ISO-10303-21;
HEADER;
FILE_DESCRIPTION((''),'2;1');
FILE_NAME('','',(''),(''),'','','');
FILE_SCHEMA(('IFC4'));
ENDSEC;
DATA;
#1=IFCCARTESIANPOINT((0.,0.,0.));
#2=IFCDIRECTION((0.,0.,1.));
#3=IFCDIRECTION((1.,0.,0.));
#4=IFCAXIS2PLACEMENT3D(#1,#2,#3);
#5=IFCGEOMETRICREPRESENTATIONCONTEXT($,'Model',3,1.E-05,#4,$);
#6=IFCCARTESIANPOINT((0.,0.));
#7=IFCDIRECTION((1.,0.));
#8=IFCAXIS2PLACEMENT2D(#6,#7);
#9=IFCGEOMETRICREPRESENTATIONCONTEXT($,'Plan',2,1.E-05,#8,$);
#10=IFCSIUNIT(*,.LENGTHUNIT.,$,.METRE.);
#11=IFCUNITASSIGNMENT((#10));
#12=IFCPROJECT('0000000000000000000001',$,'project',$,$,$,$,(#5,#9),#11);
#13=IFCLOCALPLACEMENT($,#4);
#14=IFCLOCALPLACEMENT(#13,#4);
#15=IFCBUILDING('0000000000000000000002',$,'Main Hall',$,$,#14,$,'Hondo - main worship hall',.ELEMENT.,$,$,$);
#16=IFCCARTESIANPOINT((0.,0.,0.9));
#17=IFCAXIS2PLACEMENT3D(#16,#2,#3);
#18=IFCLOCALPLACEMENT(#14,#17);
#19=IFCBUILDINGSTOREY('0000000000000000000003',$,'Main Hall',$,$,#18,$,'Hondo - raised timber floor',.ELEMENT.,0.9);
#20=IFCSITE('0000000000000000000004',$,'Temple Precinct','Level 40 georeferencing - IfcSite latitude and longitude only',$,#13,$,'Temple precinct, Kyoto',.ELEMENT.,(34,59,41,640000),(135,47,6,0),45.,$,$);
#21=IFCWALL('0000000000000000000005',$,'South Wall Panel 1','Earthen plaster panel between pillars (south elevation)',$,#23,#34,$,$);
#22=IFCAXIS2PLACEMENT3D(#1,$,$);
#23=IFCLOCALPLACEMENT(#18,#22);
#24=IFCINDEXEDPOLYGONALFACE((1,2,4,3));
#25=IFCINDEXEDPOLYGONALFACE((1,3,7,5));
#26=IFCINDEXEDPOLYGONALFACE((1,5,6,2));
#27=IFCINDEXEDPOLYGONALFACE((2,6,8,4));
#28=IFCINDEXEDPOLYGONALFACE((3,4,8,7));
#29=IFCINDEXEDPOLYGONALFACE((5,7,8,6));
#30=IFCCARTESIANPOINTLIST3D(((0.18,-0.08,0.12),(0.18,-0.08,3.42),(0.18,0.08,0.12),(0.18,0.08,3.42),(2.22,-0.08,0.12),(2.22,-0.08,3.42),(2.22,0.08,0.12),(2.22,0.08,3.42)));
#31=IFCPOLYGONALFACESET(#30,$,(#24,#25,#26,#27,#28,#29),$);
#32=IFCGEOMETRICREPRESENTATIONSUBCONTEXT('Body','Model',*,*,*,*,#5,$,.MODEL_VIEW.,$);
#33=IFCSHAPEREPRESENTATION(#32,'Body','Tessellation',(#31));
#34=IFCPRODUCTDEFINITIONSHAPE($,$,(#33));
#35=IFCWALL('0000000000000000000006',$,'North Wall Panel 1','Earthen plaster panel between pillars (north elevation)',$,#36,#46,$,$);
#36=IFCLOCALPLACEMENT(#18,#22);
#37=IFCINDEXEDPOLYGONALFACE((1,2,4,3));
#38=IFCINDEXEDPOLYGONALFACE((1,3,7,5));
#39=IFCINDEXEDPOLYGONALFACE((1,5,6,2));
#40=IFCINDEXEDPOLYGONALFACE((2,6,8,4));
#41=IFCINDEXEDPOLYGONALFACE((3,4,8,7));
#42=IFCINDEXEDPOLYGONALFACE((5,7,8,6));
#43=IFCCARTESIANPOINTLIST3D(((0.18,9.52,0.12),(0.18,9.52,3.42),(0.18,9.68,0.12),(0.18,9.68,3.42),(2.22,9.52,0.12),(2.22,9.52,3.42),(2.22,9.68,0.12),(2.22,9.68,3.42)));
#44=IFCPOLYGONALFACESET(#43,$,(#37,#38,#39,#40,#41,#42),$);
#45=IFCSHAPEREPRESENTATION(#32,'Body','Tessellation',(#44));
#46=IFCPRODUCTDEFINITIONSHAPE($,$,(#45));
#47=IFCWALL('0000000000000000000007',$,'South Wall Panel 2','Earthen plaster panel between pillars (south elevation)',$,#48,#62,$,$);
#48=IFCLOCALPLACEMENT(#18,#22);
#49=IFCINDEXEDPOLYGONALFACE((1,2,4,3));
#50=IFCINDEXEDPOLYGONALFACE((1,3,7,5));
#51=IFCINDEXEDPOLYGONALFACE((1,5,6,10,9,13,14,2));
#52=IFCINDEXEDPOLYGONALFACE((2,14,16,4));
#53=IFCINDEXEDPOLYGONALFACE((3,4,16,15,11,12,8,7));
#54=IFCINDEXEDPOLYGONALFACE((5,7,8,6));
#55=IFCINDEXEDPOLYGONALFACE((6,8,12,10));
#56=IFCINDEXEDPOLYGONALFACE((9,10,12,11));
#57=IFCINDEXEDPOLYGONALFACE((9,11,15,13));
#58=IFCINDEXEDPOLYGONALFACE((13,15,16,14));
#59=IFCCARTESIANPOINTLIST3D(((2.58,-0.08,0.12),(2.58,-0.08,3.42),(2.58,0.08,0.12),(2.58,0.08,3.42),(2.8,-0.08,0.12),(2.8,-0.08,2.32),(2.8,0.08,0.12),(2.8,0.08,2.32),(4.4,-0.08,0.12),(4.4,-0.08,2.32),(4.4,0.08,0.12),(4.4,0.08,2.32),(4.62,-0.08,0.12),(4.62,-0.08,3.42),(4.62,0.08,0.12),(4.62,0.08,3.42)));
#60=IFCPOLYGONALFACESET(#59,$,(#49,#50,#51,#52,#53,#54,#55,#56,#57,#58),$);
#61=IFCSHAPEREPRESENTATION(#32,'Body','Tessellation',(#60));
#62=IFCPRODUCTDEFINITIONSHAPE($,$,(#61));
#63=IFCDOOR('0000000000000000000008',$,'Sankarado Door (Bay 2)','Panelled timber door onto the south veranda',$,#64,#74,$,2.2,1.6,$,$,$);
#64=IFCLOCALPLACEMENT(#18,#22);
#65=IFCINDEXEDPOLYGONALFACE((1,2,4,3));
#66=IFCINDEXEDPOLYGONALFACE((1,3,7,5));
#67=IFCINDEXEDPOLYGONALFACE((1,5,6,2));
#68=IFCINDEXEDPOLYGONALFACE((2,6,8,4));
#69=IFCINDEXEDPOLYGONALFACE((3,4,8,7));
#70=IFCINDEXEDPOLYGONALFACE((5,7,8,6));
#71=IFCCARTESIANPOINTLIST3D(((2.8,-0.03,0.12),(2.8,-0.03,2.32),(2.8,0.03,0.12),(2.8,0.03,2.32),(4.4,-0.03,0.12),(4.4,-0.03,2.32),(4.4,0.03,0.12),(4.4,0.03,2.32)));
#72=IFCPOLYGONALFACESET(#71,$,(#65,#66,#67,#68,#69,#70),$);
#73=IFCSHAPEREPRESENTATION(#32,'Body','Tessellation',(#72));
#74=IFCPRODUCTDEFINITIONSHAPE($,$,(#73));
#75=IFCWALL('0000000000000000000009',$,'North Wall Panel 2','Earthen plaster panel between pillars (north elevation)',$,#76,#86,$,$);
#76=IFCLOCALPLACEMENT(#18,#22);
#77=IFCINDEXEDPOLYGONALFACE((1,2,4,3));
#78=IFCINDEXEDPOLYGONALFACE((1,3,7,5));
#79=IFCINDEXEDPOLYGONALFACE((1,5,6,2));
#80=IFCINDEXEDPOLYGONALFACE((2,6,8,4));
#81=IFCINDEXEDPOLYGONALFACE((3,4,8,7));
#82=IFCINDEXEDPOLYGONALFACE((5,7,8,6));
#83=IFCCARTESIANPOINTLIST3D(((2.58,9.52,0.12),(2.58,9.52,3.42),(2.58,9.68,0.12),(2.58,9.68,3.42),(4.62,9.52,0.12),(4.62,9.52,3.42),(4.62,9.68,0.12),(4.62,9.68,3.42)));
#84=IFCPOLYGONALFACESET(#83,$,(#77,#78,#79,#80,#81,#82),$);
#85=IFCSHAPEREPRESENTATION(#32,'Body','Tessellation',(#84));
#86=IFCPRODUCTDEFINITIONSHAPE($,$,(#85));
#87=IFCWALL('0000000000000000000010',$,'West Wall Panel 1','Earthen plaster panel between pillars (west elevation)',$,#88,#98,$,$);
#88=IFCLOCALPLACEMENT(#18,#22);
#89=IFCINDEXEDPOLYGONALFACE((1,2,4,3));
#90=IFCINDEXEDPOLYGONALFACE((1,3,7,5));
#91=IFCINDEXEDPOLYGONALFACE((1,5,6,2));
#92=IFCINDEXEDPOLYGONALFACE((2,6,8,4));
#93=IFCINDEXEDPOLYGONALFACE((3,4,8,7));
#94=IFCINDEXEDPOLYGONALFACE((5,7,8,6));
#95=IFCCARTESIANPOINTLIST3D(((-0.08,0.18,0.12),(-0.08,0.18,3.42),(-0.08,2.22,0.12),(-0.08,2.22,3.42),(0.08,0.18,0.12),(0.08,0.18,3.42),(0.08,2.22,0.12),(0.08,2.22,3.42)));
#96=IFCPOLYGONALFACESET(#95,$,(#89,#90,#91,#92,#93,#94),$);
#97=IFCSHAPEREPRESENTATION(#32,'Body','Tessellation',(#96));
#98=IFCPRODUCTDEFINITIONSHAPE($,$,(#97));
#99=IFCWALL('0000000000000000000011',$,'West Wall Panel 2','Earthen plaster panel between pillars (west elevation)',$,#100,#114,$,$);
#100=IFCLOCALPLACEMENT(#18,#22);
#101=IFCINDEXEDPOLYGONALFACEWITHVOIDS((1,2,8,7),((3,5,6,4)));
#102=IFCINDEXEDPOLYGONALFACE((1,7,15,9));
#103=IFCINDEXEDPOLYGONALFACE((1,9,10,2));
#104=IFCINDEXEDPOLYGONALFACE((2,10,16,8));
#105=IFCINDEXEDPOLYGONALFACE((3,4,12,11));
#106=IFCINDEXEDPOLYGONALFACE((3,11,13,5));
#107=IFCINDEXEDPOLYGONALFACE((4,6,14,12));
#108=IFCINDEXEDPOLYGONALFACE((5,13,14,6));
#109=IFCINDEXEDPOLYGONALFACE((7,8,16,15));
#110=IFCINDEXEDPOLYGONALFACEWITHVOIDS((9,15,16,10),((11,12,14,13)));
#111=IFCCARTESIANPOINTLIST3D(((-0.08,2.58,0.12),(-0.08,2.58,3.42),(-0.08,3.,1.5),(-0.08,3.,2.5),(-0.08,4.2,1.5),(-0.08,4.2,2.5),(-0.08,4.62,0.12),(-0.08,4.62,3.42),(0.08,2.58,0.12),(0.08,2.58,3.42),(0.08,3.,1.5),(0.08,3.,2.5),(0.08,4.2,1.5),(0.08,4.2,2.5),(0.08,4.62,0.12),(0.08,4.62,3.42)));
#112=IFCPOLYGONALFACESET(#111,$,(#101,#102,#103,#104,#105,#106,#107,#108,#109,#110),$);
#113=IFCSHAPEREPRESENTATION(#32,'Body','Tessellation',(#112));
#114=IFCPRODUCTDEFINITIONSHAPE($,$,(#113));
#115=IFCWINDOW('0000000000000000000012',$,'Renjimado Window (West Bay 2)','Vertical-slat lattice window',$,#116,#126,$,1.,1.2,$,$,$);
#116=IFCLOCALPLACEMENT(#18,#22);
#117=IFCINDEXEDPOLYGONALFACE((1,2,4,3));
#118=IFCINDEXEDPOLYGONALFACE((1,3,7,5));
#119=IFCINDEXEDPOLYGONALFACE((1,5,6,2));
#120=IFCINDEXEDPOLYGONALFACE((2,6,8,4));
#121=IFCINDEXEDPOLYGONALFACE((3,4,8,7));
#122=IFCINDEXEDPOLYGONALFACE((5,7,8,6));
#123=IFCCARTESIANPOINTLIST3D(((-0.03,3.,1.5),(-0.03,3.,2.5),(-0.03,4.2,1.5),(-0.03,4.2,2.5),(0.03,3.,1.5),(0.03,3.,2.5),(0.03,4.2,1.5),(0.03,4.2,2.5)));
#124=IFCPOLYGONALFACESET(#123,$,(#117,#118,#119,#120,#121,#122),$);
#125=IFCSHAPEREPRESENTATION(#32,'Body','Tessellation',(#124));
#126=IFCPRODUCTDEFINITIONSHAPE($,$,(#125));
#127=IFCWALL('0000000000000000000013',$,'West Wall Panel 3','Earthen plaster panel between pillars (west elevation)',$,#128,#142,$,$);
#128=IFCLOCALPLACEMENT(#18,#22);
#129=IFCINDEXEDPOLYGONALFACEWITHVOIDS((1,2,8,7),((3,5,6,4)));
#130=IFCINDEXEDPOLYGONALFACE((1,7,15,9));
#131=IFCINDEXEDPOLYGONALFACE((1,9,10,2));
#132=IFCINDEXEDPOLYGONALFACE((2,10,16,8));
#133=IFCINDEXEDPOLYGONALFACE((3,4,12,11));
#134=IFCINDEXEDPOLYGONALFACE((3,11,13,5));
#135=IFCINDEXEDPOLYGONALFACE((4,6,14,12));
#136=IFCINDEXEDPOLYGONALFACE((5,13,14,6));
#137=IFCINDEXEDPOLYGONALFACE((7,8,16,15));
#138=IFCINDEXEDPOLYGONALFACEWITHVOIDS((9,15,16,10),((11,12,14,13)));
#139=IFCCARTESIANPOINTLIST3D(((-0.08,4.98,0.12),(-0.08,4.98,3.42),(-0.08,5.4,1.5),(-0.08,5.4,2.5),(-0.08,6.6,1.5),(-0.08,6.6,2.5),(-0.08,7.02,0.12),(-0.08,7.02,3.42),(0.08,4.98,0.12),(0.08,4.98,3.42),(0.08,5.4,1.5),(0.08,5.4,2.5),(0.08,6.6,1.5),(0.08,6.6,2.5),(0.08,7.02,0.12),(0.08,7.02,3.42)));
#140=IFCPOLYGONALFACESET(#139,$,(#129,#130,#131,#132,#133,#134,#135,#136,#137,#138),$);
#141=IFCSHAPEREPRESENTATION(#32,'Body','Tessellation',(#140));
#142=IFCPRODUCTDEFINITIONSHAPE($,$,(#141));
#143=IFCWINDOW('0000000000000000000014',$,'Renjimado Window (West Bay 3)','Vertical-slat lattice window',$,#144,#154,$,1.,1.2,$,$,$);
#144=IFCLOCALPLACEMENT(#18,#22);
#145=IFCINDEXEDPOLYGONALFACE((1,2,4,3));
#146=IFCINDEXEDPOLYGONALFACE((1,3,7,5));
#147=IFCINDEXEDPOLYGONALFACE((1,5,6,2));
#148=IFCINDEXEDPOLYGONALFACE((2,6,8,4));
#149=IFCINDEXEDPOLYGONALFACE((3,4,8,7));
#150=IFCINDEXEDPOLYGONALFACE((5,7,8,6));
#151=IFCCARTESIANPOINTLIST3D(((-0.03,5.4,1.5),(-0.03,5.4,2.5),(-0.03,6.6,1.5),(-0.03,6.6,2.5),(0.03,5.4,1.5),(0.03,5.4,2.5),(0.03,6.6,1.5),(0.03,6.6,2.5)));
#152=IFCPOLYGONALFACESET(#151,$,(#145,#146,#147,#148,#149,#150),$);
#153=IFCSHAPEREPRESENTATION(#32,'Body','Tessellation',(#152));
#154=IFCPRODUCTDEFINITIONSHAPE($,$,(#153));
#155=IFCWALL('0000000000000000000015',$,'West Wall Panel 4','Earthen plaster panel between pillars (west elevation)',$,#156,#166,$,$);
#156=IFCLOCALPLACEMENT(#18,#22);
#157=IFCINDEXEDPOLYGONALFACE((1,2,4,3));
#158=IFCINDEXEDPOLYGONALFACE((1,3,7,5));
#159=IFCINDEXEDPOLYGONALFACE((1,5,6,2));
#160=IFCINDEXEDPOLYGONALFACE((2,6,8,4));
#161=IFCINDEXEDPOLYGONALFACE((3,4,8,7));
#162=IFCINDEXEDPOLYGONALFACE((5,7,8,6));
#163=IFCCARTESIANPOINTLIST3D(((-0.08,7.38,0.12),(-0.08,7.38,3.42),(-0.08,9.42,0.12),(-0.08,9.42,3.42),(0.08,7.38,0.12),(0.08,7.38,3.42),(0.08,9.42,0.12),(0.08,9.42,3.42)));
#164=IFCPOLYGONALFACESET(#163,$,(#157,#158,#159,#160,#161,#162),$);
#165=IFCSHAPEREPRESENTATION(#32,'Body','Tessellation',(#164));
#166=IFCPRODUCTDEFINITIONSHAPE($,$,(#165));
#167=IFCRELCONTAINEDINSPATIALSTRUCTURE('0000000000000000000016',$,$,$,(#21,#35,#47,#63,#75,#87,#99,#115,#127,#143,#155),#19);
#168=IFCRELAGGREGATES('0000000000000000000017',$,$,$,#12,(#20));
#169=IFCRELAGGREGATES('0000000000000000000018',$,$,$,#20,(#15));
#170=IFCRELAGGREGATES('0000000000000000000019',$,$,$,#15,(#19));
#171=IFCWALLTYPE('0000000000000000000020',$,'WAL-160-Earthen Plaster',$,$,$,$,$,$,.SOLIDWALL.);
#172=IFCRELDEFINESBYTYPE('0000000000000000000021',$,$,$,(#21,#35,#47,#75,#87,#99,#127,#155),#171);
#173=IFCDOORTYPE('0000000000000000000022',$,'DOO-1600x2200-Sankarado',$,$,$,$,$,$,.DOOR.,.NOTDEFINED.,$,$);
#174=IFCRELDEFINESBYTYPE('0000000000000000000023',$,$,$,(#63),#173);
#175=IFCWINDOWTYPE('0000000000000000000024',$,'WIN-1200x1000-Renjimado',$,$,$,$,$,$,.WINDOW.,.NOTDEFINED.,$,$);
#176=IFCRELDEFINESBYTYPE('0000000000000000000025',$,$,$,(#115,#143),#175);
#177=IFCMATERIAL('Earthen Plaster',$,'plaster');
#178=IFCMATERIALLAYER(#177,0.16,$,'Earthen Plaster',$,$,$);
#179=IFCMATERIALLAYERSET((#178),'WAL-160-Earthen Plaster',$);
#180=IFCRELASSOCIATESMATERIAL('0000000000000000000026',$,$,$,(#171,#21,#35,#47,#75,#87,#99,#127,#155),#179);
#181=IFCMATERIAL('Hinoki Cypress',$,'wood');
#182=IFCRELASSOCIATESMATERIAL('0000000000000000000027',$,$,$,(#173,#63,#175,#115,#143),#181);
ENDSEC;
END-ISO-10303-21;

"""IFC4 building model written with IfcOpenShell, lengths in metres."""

from ifc_helpers import new_model, si_unit, frame, origin_with_axes, origin_2d_with_axis, place, context, subcontext, project, spatial, line, indexed_curve, outline, extrude, material, layer, layer_set, layer_usage, type_object, element, fill, save


model = new_model("IFC4")

# Units and contexts
model_context = context("Model", 3, precision=1e-05, world=origin_with_axes())
plan_context = context("Plan", 2, precision=1e-05, world=origin_2d_with_axis())
body_context = subcontext(model_context, "Body", "Model", "MODEL_VIEW")
ifc_project = project(units=[si_unit("LENGTHUNIT", "METRE")], contexts=[model_context, plan_context])

# Site, building, storey
site_placement = place(None, origin_with_axes())
site = spatial("IfcSite", under=ifc_project, at=site_placement, Name="Temple Precinct", Description="Level 40 georeferencing - IfcSite latitude and longitude only", LongName="Temple precinct, Kyoto", CompositionType="ELEMENT", RefLatitude=(34, 59, 41, 640000), RefLongitude=(135, 47, 6, 0), RefElevation=45.0)
building_placement = place(site_placement, origin_with_axes())
building = spatial("IfcBuilding", under=site, at=building_placement, Name="Main Hall", LongName="Hondo - main worship hall", CompositionType="ELEMENT")
storey_placement = place(building_placement, frame((0.0, 0.0, 0.9), z_axis=(0.0, 0.0, 1.0), x_axis=(1.0, 0.0, 0.0)))
storey = spatial("IfcBuildingStorey", under=building, at=storey_placement, Name="Main Hall", LongName="Hondo - raised timber floor", CompositionType="ELEMENT", Elevation=0.9)

# Shared definitions
ifc_material_1 = material(Name="Hinoki Cypress", Category="wood")

# Walls
ifc_material_2 = material(Name="Earthen Plaster", Category="plaster")
ifc_layer_1 = layer(ifc_material_2, 0.16, Name="Earthen Plaster")
ifc_layer_set_1 = layer_set([ifc_layer_1], Name="WAL-160-Earthen Plaster")
ifc_layer_usage_1 = layer_usage(ifc_layer_set_1, "AXIS2", "POSITIVE", 0.0)
wall_type = type_object("IfcWallType", Name="WAL-160-Earthen Plaster", PredefinedType="SOLIDWALL", material=ifc_layer_set_1)
wall_1_placement = place(storey_placement, frame((0.18, -0.08, 0.12), z_axis=(0.0, 0.0, 1.0), x_axis=(1.0, 0.0, 0.0)))
element("IfcWall", 1, at=wall_1_placement, inside=storey, type_object=wall_type, material=ifc_layer_usage_1, Name="South Wall Panel 1", Description="Earthen plaster panel between pillars (south elevation)", context=body_context, shape_type="SweptSolid", body=[
    extrude(outline(indexed_curve([(0.0, 0.0), (0.0, 0.16), (2.04, 0.16), (2.04, 0.0), (0.0, 0.0)], self_intersect=False)), origin_with_axes(), (0.0, 0.0, 1.0), 3.3),
])
ifc_layer_usage_2 = layer_usage(ifc_layer_set_1, "AXIS2", "POSITIVE", 0.0)
wall_2_placement = place(storey_placement, frame((0.18, 9.52, 0.12), z_axis=(0.0, 0.0, 1.0), x_axis=(1.0, 0.0, 0.0)))
element("IfcWall", 2, at=wall_2_placement, inside=storey, type_object=wall_type, material=ifc_layer_usage_2, Name="North Wall Panel 1", Description="Earthen plaster panel between pillars (north elevation)", context=body_context, shape_type="SweptSolid", body=[
    extrude(outline(indexed_curve([(0.0, 0.0), (0.0, 0.16), (2.04, 0.16), (2.04, 0.0), (0.0, 0.0)], self_intersect=False)), origin_with_axes(), (0.0, 0.0, 1.0), 3.3),
])

# Wall, opening, door
ifc_layer_usage_3 = layer_usage(ifc_layer_set_1, "AXIS2", "POSITIVE", 0.0)
wall_3_placement = place(storey_placement, frame((2.58, -0.08, 0.12), z_axis=(0.0, 0.0, 1.0), x_axis=(1.0, 0.0, 0.0)))
wall_3 = element("IfcWall", 3, at=wall_3_placement, inside=storey, type_object=wall_type, material=ifc_layer_usage_3, Name="South Wall Panel 2", Description="Earthen plaster panel between pillars (south elevation)", context=body_context, shape_type="SweptSolid", body=[
    extrude(outline(indexed_curve([(0.0, 0.0), (0.0, 0.16), (2.04, 0.16), (2.04, 0.0), (0.0, 0.0)], self_intersect=False)), origin_with_axes(), (0.0, 0.0, 1.0), 3.3),
])
opening_1_placement = place(wall_3_placement, frame((0.22, -0.01, 0.0), z_axis=(0.0, 0.0, 1.0), x_axis=(1.0, 0.0, 0.0)))
opening_1 = element("IfcOpeningElement", 4, at=opening_1_placement, cuts=wall_3, PredefinedType="OPENING", context=body_context, shape_type="SweptSolid", body=[
    extrude(outline(indexed_curve([(0.0, 0.0), (1.6, 0.0), (1.6, 0.18), (0.0, 0.18)], segments=[line(1, 2, 3, 4, 1)])), origin_with_axes(), (0.0, 0.0, 1.0), 2.2),
])
door_type = type_object("IfcDoorType", Name="DOO-1600x2200-Sankarado", OperationType="NOTDEFINED", PredefinedType="DOOR", material=ifc_material_1)
door_placement = place(storey_placement, frame((2.8, -0.03, 0.12), z_axis=(0.0, 0.0, 1.0), x_axis=(1.0, 0.0, 0.0)))
door = element("IfcDoor", 5, at=door_placement, inside=storey, type_object=door_type, material=ifc_material_1, Name="Sankarado Door (Bay 2)", Description="Panelled timber door onto the south veranda", OverallHeight=2.2, OverallWidth=1.6, context=body_context, shape_type="SweptSolid", body=[
    extrude(outline(indexed_curve([(0.0, 0.0), (1.6, 0.0), (1.6, 0.06), (0.0, 0.06)], segments=[line(1, 2, 3, 4, 1)])), origin_with_axes(), (0.0, 0.0, 1.0), 2.2),
])
fill(opening_1, door)

# Walls
ifc_layer_usage_4 = layer_usage(ifc_layer_set_1, "AXIS2", "POSITIVE", 0.0)
wall_4_placement = place(storey_placement, frame((2.58, 9.52, 0.12), z_axis=(0.0, 0.0, 1.0), x_axis=(1.0, 0.0, 0.0)))
element("IfcWall", 6, at=wall_4_placement, inside=storey, type_object=wall_type, material=ifc_layer_usage_4, Name="North Wall Panel 2", Description="Earthen plaster panel between pillars (north elevation)", context=body_context, shape_type="SweptSolid", body=[
    extrude(outline(indexed_curve([(0.0, 0.0), (0.0, 0.16), (2.04, 0.16), (2.04, 0.0), (0.0, 0.0)], self_intersect=False)), origin_with_axes(), (0.0, 0.0, 1.0), 3.3),
])
ifc_layer_usage_5 = layer_usage(ifc_layer_set_1, "AXIS2", "POSITIVE", 0.0)
wall_5_placement = place(storey_placement, frame((0.08, 0.18, 0.12), z_axis=(0.0, 0.0, 1.0), x_axis=(0.0, 1.0, 0.0)))
element("IfcWall", 7, at=wall_5_placement, inside=storey, type_object=wall_type, material=ifc_layer_usage_5, Name="West Wall Panel 1", Description="Earthen plaster panel between pillars (west elevation)", context=body_context, shape_type="SweptSolid", body=[
    extrude(outline(indexed_curve([(0.0, 0.0), (0.0, 0.16), (2.04, 0.16), (2.04, 0.0), (0.0, 0.0)], self_intersect=False)), origin_with_axes(), (0.0, 0.0, 1.0), 3.3),
])

# Walls, openings, windows
ifc_layer_usage_6 = layer_usage(ifc_layer_set_1, "AXIS2", "POSITIVE", 0.0)
wall_6_placement = place(storey_placement, frame((0.08, 2.58, 0.12), z_axis=(0.0, 0.0, 1.0), x_axis=(0.0, 1.0, 0.0)))
wall_6 = element("IfcWall", 8, at=wall_6_placement, inside=storey, type_object=wall_type, material=ifc_layer_usage_6, Name="West Wall Panel 2", Description="Earthen plaster panel between pillars (west elevation)", context=body_context, shape_type="SweptSolid", body=[
    extrude(outline(indexed_curve([(0.0, 0.0), (0.0, 0.16), (2.04, 0.16), (2.04, 0.0), (0.0, 0.0)], self_intersect=False)), origin_with_axes(), (0.0, 0.0, 1.0), 3.3),
])
opening_2_placement = place(wall_6_placement, frame((0.42, 0.17, 1.38), z_axis=(0.0, 0.0, 1.0), x_axis=(0.0, -1.0, 0.0)))
opening_2 = element("IfcOpeningElement", 9, at=opening_2_placement, cuts=wall_6, PredefinedType="OPENING", context=body_context, shape_type="SweptSolid", body=[
    extrude(outline(indexed_curve([(0.0, 0.0), (0.18, 0.0), (0.18, 1.2), (0.0, 1.2)], segments=[line(1, 2, 3, 4, 1)])), origin_with_axes(), (0.0, 0.0, 1.0), 1.0),
])
window_type = type_object("IfcWindowType", Name="WIN-1200x1000-Renjimado", PartitioningType="NOTDEFINED", PredefinedType="WINDOW", material=ifc_material_1)
window_1_placement = place(storey_placement, frame((-0.03, 3.0, 1.5), z_axis=(0.0, 0.0, 1.0), x_axis=(1.0, 0.0, 0.0)))
window_1 = element("IfcWindow", 10, at=window_1_placement, inside=storey, type_object=window_type, material=ifc_material_1, Name="Renjimado Window (West Bay 2)", Description="Vertical-slat lattice window", OverallHeight=1.0, OverallWidth=1.2, context=body_context, shape_type="SweptSolid", body=[
    extrude(outline(indexed_curve([(0.0, 0.0), (0.06, 0.0), (0.06, 1.2), (0.0, 1.2)], segments=[line(1, 2, 3, 4, 1)])), origin_with_axes(), (0.0, 0.0, 1.0), 1.0),
])
fill(opening_2, window_1)
ifc_layer_usage_7 = layer_usage(ifc_layer_set_1, "AXIS2", "POSITIVE", 0.0)
wall_7_placement = place(storey_placement, frame((0.08, 4.98, 0.12), z_axis=(0.0, 0.0, 1.0), x_axis=(0.0, 1.0, 0.0)))
wall_7 = element("IfcWall", 11, at=wall_7_placement, inside=storey, type_object=wall_type, material=ifc_layer_usage_7, Name="West Wall Panel 3", Description="Earthen plaster panel between pillars (west elevation)", context=body_context, shape_type="SweptSolid", body=[
    extrude(outline(indexed_curve([(0.0, 0.0), (0.0, 0.16), (2.04, 0.16), (2.04, 0.0), (0.0, 0.0)], self_intersect=False)), origin_with_axes(), (0.0, 0.0, 1.0), 3.3),
])
opening_3_placement = place(wall_7_placement, frame((0.42, 0.17, 1.38), z_axis=(0.0, 0.0, 1.0), x_axis=(0.0, -1.0, 0.0)))
opening_3 = element("IfcOpeningElement", 12, at=opening_3_placement, cuts=wall_7, PredefinedType="OPENING", context=body_context, shape_type="SweptSolid", body=[
    extrude(outline(indexed_curve([(0.0, 0.0), (0.18, 0.0), (0.18, 1.2), (0.0, 1.2)], segments=[line(1, 2, 3, 4, 1)])), origin_with_axes(), (0.0, 0.0, 1.0), 1.0),
])
window_2_placement = place(storey_placement, frame((-0.03, 5.4, 1.5), z_axis=(0.0, 0.0, 1.0), x_axis=(1.0, 0.0, 0.0)))
window_2 = element("IfcWindow", 13, at=window_2_placement, inside=storey, type_object=window_type, material=ifc_material_1, Name="Renjimado Window (West Bay 3)", Description="Vertical-slat lattice window", OverallHeight=1.0, OverallWidth=1.2, context=body_context, shape_type="SweptSolid", body=[
    extrude(outline(indexed_curve([(0.0, 0.0), (0.06, 0.0), (0.06, 1.2), (0.0, 1.2)], segments=[line(1, 2, 3, 4, 1)])), origin_with_axes(), (0.0, 0.0, 1.0), 1.0),
])
fill(opening_3, window_2)

# Wall
ifc_layer_usage_8 = layer_usage(ifc_layer_set_1, "AXIS2", "POSITIVE", 0.0)
wall_8_placement = place(storey_placement, frame((0.08, 7.38, 0.12), z_axis=(0.0, 0.0, 1.0), x_axis=(0.0, 1.0, 0.0)))
element("IfcWall", 14, at=wall_8_placement, inside=storey, type_object=wall_type, material=ifc_layer_usage_8, Name="West Wall Panel 4", Description="Earthen plaster panel between pillars (west elevation)", context=body_context, shape_type="SweptSolid", body=[
    extrude(outline(indexed_curve([(0.0, 0.0), (0.0, 0.16), (2.04, 0.16), (2.04, 0.0), (0.0, 0.0)], self_intersect=False)), origin_with_axes(), (0.0, 0.0, 1.0), 3.3),
])

save(model, "model.ifc")
